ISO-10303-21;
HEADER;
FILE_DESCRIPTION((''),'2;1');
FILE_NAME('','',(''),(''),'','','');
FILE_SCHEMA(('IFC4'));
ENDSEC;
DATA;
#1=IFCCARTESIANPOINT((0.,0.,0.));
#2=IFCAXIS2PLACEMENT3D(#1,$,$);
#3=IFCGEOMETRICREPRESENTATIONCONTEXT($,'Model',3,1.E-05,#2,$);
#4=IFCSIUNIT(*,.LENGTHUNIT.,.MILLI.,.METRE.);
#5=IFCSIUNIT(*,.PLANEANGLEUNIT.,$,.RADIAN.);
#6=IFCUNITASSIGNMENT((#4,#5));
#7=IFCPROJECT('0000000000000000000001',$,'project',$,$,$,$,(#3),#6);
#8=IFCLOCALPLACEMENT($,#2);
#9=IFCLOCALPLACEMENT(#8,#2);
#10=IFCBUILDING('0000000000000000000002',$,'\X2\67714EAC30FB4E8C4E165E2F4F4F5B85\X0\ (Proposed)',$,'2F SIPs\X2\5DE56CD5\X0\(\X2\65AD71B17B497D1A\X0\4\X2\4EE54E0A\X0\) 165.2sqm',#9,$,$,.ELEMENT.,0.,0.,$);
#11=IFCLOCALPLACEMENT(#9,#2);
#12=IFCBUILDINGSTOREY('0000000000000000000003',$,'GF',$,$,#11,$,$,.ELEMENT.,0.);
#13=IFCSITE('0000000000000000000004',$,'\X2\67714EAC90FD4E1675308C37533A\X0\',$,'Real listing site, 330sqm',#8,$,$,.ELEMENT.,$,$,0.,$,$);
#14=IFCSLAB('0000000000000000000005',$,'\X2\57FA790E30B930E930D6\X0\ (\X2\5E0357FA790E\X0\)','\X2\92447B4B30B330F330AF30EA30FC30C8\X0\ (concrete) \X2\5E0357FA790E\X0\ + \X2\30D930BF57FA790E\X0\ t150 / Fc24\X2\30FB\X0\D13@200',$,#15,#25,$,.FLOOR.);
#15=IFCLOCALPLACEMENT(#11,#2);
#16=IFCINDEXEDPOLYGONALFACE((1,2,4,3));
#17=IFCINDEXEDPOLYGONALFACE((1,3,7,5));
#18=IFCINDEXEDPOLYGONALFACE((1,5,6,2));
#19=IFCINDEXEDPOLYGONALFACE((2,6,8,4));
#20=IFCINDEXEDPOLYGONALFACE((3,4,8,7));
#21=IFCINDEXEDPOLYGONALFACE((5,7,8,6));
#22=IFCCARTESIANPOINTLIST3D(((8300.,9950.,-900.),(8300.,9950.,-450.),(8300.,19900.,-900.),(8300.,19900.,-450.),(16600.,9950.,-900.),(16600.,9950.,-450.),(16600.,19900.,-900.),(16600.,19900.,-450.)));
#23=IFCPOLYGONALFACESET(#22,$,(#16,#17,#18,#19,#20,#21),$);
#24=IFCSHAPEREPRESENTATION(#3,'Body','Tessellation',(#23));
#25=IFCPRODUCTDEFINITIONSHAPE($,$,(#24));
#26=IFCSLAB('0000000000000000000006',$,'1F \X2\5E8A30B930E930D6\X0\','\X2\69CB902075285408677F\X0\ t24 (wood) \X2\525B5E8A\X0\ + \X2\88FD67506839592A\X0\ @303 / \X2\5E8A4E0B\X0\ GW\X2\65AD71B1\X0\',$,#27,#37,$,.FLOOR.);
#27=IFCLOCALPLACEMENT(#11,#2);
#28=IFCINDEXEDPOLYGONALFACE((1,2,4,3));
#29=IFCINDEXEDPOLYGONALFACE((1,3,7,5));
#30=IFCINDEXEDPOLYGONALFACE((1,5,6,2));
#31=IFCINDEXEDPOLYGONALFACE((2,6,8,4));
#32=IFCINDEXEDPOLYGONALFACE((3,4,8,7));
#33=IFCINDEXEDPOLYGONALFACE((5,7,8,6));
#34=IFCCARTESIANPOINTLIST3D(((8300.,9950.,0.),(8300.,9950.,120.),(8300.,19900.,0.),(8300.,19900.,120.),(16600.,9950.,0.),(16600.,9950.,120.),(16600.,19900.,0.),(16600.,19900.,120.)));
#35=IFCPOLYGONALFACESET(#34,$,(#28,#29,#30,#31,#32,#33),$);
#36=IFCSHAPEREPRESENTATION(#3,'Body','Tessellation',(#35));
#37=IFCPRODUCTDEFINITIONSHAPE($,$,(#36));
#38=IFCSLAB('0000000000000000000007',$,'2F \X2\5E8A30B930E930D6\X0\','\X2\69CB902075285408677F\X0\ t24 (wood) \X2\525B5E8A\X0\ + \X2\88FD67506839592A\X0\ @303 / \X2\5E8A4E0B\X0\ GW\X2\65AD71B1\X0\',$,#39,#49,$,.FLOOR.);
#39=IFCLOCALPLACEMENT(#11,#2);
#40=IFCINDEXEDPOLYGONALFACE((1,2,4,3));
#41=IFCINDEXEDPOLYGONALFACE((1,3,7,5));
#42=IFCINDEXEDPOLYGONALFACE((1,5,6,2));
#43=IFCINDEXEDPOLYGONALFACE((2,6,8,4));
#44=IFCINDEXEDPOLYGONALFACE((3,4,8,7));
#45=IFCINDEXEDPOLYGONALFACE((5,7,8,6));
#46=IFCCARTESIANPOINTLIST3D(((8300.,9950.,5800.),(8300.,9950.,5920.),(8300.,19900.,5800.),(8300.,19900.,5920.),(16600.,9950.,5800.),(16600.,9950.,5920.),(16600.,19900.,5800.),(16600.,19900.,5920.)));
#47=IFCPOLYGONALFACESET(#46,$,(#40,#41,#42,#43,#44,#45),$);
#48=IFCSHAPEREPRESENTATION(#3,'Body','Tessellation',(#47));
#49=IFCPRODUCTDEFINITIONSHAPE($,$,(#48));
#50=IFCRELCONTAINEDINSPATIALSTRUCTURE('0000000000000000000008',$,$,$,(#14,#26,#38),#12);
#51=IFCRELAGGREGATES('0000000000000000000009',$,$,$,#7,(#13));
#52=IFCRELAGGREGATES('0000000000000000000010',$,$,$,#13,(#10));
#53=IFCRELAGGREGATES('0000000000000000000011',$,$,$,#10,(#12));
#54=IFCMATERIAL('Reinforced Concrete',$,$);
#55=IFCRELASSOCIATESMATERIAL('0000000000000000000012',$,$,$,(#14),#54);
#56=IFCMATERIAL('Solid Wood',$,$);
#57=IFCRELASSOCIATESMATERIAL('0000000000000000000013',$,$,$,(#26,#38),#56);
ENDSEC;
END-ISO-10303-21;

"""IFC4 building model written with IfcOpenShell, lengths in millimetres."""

from ifc_helpers import new_model, si_unit, frame, frame_2d, origin, place, context, project, spatial, rectangle, extrude, material, element, save


model = new_model("IFC4")

# Units and contexts
model_context = context("Model", 3, precision=1e-05, world=origin())
ifc_project = project(units=[si_unit("LENGTHUNIT", "METRE", prefix="MILLI"), si_unit("PLANEANGLEUNIT", "RADIAN")], contexts=[model_context])

# Site, building, storey
site_placement = place(None, origin())
site = spatial("IfcSite", under=ifc_project, at=site_placement, Name="東京都世田谷区", ObjectType="Real listing site, 330sqm", CompositionType="ELEMENT", RefElevation=0.0)
building_placement = place(site_placement, origin())
building = spatial("IfcBuilding", under=site, at=building_placement, Name="東京・二世帯住宅 (Proposed)", ObjectType="2F SIPs工法(断熱等級4以上) 165.2sqm", CompositionType="ELEMENT", ElevationOfRefHeight=0.0, ElevationOfTerrain=0.0)
storey_placement = place(building_placement, origin())
storey = spatial("IfcBuildingStorey", under=building, at=storey_placement, Name="GF", CompositionType="ELEMENT", Elevation=0.0)

# Shared definitions
ifc_material_1 = material(Name="Solid Wood")

# Slabs
ifc_material_2 = material(Name="Reinforced Concrete")
slab_1_placement = place(storey_placement, frame((4150.0, 4975.0, -450.0)))
element("IfcSlab", 1, at=slab_1_placement, inside=storey, material=ifc_material_2, Name="基礎スラブ (布基礎)", Description="鉄筋コンクリート (concrete) 布基礎 + ベタ基礎 t150 / Fc24・D13@200", PredefinedType="FLOOR", context=model_context, shape_type="SweptSolid", body=[
    extrude(rectangle(XDim=8300.0, YDim=9950.0, at=frame_2d((4150.0, 4975.0))), frame((4150.0, 4975.0, -450.0)), (0.0, 0.0, 1.0), 450.0),
])
slab_2_placement = place(storey_placement, frame((4150.0, 4975.0, 0.0)))
element("IfcSlab", 2, at=slab_2_placement, inside=storey, material=ifc_material_1, Name="1F 床スラブ", Description="構造用合板 t24 (wood) 剛床 + 製材根太 @303 / 床下 GW断熱", PredefinedType="FLOOR", context=model_context, shape_type="SweptSolid", body=[
    extrude(rectangle(XDim=8300.0, YDim=9950.0, at=frame_2d((4150.0, 4975.0))), frame((4150.0, 4975.0, 0.0)), (0.0, 0.0, 1.0), 120.0),
])
slab_3_placement = place(storey_placement, frame((4150.0, 4975.0, 2900.0)))
element("IfcSlab", 3, at=slab_3_placement, inside=storey, material=ifc_material_1, Name="2F 床スラブ", Description="構造用合板 t24 (wood) 剛床 + 製材根太 @303 / 床下 GW断熱", PredefinedType="FLOOR", context=model_context, shape_type="SweptSolid", body=[
    extrude(rectangle(XDim=8300.0, YDim=9950.0, at=frame_2d((4150.0, 4975.0))), frame((4150.0, 4975.0, 2900.0)), (0.0, 0.0, 1.0), 120.0),
])

save(model, "model.ifc")
